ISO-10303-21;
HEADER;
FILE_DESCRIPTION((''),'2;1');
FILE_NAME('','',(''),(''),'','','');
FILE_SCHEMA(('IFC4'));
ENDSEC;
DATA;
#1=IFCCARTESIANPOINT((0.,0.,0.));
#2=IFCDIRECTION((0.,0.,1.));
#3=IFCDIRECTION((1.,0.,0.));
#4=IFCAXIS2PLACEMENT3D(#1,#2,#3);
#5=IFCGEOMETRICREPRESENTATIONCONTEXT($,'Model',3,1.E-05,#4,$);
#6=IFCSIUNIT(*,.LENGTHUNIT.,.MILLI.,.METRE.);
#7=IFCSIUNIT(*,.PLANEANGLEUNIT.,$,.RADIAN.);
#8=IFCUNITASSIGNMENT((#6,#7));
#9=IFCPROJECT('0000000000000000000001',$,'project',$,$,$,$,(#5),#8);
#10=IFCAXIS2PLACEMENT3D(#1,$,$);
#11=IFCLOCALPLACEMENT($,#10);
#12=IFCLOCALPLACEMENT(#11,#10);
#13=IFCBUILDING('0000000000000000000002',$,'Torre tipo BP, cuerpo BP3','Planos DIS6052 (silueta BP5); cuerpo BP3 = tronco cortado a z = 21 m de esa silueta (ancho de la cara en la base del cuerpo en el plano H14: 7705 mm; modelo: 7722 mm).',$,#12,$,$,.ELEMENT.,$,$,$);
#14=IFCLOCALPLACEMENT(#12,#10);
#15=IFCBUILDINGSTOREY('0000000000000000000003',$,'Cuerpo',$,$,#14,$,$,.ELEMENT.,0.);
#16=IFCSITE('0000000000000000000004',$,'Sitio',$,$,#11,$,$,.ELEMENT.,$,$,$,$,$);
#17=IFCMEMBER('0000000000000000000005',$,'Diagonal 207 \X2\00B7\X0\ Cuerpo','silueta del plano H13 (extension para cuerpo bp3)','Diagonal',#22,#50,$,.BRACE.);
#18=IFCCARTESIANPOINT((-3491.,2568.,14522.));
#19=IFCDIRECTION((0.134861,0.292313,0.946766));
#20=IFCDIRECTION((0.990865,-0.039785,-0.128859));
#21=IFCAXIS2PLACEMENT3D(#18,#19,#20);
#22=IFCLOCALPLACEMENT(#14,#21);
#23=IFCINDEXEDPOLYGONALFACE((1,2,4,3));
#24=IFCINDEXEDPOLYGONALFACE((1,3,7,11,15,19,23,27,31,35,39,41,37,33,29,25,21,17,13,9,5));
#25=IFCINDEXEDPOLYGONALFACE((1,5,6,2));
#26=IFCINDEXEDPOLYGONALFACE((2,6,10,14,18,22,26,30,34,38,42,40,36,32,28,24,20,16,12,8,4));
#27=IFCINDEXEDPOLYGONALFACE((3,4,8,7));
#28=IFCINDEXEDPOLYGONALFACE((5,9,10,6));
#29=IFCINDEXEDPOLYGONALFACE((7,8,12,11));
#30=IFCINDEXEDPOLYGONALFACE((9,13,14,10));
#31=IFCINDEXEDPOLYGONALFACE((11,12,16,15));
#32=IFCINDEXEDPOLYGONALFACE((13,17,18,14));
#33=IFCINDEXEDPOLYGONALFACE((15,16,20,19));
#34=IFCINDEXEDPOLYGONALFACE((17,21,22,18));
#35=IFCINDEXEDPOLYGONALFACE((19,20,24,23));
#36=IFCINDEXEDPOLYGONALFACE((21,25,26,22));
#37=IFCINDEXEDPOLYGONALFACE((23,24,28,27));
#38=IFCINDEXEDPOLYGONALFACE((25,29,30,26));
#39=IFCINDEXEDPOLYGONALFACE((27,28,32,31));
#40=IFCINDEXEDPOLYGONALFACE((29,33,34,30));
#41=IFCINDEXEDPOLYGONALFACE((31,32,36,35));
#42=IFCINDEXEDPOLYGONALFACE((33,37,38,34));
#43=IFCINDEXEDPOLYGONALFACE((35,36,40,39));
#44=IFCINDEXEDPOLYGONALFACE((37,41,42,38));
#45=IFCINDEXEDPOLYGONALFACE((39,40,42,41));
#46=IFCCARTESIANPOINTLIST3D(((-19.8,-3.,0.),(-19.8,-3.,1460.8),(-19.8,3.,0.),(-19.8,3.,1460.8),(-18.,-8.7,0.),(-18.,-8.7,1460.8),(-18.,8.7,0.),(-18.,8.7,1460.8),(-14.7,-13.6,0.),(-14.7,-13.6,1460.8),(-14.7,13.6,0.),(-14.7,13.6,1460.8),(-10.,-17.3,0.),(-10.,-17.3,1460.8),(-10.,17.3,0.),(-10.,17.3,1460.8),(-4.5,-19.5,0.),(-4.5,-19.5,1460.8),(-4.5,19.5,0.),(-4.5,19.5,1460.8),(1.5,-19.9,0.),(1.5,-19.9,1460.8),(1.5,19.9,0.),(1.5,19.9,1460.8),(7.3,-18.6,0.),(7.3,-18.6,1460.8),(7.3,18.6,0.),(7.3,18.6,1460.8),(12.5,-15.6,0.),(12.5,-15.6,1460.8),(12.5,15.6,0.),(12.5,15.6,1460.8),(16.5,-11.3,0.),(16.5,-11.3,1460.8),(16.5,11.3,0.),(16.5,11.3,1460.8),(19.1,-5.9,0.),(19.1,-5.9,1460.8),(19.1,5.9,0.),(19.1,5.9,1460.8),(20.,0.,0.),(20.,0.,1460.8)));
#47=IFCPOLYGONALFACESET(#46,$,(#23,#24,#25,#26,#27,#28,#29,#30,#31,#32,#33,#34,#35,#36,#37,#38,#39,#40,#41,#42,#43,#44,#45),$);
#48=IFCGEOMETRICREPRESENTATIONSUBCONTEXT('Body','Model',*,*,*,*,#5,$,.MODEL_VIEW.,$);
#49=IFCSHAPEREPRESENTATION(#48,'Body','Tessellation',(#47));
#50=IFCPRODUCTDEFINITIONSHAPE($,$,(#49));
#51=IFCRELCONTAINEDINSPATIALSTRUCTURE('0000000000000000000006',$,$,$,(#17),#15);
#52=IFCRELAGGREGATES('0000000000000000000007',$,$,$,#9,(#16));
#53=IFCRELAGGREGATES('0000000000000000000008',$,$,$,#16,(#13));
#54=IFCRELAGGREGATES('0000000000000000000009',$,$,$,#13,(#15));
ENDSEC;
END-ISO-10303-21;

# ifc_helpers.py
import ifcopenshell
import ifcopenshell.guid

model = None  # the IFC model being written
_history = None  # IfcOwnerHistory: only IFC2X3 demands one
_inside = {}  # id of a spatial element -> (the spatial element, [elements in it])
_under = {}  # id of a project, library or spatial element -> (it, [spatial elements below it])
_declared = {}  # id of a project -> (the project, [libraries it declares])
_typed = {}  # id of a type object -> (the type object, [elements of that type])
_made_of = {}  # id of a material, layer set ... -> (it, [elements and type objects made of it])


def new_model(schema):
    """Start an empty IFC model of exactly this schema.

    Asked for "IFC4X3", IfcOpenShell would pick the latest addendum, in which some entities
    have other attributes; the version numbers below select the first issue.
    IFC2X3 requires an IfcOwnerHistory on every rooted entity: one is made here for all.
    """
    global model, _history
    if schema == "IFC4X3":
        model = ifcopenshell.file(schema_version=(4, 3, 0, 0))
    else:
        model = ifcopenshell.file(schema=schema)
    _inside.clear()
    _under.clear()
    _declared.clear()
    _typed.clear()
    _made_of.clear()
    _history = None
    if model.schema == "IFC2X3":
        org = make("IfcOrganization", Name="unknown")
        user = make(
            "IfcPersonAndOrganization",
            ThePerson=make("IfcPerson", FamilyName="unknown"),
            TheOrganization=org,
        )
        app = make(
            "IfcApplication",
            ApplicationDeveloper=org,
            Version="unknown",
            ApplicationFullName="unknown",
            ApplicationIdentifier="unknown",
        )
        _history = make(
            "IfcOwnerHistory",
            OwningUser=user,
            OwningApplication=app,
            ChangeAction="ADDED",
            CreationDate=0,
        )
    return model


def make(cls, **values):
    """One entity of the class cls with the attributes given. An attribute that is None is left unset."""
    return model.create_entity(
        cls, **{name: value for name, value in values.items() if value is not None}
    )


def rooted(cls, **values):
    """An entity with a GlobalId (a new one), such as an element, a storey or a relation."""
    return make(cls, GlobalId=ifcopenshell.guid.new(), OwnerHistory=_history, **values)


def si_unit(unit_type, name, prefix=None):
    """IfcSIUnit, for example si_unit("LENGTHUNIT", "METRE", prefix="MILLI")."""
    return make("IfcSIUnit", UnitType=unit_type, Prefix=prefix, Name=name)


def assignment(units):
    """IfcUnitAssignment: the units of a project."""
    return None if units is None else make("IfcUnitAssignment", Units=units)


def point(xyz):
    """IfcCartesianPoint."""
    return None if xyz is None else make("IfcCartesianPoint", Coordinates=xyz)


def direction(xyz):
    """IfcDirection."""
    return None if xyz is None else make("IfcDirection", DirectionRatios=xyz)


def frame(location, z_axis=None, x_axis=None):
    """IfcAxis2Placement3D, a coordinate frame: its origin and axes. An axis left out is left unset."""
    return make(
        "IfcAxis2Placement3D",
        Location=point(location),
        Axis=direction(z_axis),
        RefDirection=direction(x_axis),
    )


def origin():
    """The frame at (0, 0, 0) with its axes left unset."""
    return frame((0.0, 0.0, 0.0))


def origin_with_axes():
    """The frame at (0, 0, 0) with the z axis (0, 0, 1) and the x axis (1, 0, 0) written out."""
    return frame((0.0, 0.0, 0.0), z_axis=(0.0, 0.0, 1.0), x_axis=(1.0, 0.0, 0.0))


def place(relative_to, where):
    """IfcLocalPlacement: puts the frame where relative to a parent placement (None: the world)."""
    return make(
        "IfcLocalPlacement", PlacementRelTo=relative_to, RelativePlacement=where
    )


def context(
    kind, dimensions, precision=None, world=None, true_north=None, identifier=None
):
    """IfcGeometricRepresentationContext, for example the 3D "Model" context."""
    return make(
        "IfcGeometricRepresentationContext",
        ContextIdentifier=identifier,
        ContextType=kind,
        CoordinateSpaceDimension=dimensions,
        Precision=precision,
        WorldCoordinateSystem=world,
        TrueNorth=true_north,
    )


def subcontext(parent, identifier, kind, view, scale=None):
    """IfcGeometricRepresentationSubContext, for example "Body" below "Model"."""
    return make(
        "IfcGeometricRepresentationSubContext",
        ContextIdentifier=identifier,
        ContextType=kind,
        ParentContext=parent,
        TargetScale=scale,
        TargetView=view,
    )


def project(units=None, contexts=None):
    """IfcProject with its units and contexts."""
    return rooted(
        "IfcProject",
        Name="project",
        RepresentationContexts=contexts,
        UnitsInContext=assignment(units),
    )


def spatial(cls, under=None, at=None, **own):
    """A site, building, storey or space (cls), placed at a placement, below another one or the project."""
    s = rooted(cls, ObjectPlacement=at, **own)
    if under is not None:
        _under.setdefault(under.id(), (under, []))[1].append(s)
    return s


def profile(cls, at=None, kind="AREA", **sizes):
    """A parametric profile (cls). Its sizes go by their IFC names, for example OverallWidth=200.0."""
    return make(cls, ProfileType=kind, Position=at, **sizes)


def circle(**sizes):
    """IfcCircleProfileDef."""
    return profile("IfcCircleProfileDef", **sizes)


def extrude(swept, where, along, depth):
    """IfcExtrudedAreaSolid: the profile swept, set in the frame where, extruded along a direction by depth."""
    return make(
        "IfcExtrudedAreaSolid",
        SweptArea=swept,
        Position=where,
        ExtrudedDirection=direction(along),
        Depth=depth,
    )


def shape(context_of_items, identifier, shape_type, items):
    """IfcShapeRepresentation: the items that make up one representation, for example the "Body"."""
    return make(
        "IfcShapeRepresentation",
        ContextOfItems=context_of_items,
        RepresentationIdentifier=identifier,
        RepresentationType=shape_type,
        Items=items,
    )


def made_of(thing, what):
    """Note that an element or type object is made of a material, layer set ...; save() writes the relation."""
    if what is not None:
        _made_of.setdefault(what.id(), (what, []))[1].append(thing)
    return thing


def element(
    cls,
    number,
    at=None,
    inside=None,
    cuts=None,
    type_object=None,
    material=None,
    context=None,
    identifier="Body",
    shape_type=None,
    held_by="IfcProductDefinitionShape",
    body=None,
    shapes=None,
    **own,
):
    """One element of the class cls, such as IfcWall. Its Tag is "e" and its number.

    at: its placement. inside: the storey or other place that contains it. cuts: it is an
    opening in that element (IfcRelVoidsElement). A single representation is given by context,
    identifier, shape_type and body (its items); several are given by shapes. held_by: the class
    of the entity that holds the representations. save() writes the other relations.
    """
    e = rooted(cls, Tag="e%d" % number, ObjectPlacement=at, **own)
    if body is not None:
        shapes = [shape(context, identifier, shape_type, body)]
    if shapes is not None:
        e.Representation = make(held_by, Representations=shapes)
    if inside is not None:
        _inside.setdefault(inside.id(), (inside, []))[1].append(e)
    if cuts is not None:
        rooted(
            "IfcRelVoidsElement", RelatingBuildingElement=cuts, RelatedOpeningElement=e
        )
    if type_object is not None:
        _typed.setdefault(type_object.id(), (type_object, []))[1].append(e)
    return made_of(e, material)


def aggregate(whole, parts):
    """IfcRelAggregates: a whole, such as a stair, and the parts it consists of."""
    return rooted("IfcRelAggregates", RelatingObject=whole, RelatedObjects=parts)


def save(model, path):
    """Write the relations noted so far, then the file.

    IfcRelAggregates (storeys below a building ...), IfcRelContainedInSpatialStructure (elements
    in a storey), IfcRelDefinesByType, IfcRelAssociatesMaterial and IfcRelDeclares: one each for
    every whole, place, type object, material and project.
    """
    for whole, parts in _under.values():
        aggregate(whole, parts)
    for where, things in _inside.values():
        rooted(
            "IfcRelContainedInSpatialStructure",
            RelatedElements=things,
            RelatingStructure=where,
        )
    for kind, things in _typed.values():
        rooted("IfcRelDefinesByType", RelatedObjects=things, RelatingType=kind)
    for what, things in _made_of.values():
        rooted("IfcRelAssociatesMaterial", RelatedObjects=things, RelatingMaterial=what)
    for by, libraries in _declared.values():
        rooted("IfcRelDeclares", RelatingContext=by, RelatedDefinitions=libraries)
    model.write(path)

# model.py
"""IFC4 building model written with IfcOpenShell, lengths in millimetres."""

from ifc_helpers import new_model, si_unit, frame, origin, origin_with_axes, place, context, subcontext, project, spatial, circle, extrude, element, save


model = new_model("IFC4")

# Units and contexts
model_context = context("Model", 3, precision=1e-05, world=origin_with_axes())
body_context = subcontext(model_context, "Body", "Model", "MODEL_VIEW")
ifc_project = project(units=[si_unit("LENGTHUNIT", "METRE", prefix="MILLI"), si_unit("PLANEANGLEUNIT", "RADIAN")], contexts=[model_context])

# Site, building, storey
site_placement = place(None, origin())
site = spatial("IfcSite", under=ifc_project, at=site_placement, Name="Sitio", CompositionType="ELEMENT")
building_placement = place(site_placement, origin())
building = spatial("IfcBuilding", under=site, at=building_placement, Name="Torre tipo BP, cuerpo BP3", Description="Planos DIS6052 (silueta BP5); cuerpo BP3 = tronco cortado a z = 21 m de esa silueta (ancho de la cara en la base del cuerpo en el plano H14: 7705 mm; modelo: 7722 mm).", CompositionType="ELEMENT")
storey_placement = place(building_placement, origin())
storey = spatial("IfcBuildingStorey", under=building, at=storey_placement, Name="Cuerpo", CompositionType="ELEMENT", Elevation=0.0)

# Member
member_1_placement = place(storey_placement, frame((-3491.0, 2568.0, 14522.0), z_axis=(0.134861, 0.292313, 0.946766), x_axis=(0.990865, -0.039785, -0.128859)))
element("IfcMember", 1, at=member_1_placement, inside=storey, Name="Diagonal 207 · Cuerpo", Description="silueta del plano H13 (extension para cuerpo bp3)", ObjectType="Diagonal", PredefinedType="BRACE", context=body_context, shape_type="SweptSolid", body=[
    extrude(circle(Radius=20.0), None, (0.0, 0.0, 1.0), 1460.8),
])

save(model, "model.ifc")
